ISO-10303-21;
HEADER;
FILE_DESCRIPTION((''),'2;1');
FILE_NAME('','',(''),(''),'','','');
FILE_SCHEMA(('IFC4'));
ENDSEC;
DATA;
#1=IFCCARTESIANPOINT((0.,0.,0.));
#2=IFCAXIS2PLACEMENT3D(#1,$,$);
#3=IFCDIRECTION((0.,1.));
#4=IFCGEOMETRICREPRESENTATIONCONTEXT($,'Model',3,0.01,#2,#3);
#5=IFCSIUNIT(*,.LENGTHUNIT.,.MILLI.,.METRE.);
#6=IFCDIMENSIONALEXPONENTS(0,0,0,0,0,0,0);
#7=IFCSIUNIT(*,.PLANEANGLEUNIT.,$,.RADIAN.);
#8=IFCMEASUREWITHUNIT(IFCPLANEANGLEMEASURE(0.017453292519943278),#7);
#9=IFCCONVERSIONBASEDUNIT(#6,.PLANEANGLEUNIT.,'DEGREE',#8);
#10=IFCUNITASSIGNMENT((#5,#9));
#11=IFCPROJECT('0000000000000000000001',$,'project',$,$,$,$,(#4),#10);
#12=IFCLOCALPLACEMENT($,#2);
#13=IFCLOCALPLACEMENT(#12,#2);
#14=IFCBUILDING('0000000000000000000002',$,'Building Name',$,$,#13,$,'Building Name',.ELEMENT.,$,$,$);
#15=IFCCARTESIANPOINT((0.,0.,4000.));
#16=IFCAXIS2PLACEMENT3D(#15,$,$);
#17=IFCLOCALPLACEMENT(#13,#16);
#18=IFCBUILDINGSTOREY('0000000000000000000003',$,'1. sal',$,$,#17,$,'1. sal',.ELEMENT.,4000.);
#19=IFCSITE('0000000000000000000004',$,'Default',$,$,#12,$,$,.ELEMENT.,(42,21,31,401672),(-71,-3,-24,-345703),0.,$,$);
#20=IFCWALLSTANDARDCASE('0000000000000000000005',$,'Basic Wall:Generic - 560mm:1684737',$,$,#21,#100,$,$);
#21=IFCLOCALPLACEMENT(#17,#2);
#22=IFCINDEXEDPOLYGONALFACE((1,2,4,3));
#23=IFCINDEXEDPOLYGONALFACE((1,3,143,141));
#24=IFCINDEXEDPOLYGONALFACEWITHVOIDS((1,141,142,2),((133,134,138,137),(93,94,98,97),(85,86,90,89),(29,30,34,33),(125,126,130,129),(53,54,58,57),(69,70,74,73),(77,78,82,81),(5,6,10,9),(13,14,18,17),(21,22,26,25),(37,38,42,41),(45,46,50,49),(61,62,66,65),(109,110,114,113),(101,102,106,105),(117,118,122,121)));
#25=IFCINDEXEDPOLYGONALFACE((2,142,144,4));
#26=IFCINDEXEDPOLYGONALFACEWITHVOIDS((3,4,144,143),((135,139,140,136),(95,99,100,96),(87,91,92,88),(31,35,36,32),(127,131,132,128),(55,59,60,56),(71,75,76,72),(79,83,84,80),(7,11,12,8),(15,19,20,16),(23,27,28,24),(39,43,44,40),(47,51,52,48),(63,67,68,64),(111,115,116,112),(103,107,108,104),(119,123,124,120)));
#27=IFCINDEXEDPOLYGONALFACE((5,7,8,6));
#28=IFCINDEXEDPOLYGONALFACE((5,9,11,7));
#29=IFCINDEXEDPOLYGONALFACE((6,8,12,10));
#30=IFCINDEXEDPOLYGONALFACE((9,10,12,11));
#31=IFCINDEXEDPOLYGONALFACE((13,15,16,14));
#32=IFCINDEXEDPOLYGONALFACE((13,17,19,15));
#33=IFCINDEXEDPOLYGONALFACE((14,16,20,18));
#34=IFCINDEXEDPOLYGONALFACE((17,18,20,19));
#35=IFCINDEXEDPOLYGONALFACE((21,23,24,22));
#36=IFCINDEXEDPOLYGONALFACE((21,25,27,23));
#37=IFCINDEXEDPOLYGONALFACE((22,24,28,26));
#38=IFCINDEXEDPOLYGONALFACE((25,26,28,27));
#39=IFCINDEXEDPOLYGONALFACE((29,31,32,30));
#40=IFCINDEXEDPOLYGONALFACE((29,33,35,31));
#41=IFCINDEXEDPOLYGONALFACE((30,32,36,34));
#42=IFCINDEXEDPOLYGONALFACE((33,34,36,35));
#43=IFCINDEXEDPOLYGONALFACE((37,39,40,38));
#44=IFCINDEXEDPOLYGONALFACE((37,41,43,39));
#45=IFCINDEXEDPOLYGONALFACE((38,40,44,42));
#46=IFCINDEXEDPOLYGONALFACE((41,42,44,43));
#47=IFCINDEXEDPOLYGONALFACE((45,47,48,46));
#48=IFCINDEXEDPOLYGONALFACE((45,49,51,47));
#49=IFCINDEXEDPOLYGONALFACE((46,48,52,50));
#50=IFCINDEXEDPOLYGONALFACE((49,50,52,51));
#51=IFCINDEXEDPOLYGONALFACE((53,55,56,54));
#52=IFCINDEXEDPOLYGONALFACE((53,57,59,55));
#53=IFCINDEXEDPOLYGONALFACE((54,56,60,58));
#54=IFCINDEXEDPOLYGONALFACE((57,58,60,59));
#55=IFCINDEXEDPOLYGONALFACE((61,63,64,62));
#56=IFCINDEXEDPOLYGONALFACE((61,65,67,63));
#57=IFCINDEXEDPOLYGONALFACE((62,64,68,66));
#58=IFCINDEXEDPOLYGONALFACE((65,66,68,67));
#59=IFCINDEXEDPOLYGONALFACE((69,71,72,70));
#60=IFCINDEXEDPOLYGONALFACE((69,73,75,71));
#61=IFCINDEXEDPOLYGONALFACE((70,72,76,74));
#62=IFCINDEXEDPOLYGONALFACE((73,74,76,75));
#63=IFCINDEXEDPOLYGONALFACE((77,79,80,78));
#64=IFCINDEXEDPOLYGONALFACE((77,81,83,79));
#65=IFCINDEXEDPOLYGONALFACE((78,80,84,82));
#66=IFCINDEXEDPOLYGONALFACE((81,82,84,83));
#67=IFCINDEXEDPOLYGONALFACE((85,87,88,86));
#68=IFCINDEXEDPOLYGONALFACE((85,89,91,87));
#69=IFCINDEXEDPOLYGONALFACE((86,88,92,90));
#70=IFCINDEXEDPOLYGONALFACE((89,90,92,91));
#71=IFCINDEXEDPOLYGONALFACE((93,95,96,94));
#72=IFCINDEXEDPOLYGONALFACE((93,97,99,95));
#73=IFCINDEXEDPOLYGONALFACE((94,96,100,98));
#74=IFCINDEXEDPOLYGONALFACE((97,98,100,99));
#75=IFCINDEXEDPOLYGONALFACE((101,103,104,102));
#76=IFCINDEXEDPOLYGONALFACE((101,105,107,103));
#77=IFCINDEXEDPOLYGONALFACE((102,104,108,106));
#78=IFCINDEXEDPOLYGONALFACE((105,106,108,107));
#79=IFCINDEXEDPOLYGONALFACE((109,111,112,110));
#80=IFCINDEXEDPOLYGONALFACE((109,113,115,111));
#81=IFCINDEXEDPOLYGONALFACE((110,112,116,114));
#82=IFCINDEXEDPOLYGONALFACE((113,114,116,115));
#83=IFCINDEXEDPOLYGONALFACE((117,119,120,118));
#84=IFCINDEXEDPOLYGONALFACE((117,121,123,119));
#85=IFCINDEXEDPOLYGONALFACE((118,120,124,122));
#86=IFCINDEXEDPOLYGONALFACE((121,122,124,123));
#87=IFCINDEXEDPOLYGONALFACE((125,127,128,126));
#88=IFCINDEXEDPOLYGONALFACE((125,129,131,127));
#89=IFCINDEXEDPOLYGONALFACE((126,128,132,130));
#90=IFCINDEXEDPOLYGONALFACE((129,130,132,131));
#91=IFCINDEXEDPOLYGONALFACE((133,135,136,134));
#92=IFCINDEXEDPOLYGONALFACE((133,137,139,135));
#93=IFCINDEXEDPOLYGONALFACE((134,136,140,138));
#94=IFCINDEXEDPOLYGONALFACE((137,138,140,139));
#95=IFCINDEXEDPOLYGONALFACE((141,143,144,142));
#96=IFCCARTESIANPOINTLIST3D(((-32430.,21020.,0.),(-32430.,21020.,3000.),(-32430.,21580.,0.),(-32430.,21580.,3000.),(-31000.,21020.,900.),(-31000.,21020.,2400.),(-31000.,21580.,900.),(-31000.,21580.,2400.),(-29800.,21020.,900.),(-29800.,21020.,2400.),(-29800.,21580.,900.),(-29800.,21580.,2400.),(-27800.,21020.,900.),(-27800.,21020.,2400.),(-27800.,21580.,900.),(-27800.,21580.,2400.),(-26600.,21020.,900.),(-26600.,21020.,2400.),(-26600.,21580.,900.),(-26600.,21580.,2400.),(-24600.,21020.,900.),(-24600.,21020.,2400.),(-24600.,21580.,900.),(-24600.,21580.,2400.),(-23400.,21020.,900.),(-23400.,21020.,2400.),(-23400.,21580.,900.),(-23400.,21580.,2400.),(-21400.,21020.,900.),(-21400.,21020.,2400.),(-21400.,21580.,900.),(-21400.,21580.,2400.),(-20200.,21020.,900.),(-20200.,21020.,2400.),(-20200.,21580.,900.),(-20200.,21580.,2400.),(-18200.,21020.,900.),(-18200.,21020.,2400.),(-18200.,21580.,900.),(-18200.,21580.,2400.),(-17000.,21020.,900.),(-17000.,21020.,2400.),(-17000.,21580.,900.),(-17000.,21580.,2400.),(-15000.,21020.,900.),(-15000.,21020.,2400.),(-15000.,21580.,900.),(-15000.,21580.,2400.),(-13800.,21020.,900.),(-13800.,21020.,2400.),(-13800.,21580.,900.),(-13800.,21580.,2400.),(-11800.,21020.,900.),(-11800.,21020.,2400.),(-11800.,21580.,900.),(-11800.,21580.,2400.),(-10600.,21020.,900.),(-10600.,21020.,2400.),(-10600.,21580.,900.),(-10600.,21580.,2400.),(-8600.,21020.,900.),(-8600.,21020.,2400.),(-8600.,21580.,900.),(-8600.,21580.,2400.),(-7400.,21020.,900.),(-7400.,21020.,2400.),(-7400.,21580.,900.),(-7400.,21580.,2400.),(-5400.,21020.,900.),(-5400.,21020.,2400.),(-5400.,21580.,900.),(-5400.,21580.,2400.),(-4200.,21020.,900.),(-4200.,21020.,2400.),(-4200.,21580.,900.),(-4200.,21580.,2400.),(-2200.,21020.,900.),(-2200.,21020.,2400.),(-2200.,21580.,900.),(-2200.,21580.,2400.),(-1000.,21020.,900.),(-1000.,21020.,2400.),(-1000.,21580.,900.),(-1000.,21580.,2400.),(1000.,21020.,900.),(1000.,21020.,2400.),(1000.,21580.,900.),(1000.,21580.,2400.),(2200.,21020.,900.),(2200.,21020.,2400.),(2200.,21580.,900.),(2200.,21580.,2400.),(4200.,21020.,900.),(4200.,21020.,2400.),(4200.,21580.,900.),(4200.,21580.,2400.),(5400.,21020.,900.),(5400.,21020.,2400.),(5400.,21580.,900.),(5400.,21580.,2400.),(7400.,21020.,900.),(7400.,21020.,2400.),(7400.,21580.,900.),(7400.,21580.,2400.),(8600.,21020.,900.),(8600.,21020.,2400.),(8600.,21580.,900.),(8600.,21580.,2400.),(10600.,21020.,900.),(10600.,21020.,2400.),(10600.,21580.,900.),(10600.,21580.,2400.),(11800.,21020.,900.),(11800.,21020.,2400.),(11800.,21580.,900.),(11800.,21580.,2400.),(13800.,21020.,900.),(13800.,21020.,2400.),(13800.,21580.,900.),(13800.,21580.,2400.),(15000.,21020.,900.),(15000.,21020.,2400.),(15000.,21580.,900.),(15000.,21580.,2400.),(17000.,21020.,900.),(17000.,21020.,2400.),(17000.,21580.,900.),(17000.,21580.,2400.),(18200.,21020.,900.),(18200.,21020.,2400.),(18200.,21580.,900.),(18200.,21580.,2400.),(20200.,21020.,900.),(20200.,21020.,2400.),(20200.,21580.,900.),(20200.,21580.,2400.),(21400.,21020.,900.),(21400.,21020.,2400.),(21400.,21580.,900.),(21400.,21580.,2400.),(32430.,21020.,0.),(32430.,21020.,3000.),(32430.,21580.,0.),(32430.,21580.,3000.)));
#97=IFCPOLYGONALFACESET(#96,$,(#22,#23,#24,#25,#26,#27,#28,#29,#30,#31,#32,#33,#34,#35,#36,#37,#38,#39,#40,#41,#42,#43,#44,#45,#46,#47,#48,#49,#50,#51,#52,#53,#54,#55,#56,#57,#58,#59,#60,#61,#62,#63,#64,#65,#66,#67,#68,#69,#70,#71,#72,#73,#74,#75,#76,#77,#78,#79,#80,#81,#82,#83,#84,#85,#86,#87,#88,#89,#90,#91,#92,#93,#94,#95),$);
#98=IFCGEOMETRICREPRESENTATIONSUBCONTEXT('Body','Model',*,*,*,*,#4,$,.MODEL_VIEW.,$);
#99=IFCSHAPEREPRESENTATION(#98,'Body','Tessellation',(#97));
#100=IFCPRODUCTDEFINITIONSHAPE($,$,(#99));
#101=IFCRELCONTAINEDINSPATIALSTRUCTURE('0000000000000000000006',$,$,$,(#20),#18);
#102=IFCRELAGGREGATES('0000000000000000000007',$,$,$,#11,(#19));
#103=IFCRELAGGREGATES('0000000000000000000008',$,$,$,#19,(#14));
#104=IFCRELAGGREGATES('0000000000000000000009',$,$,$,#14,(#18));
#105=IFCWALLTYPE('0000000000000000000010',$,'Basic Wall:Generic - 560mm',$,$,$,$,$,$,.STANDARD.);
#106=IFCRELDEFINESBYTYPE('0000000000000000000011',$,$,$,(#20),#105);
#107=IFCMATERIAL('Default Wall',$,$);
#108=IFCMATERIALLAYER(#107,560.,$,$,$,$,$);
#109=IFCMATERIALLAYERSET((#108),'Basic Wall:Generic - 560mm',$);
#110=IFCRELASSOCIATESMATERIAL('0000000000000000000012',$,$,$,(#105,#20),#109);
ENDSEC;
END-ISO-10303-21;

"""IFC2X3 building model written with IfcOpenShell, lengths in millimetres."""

from ifc_helpers import new_model, entity, si_unit, converted_unit, direction, frame, frame_2d, origin, place, context, subcontext, project, spatial, rectangle, extrude, material, layer, layer_set, layer_usage, type_object, element, save


model = new_model("IFC2X3")

# Units and contexts
model_context = context("Model", 3, precision=0.01, world=origin(), true_north=direction((0.0, 1.0)))
body_context = subcontext(model_context, "Body", "Model", "MODEL_VIEW")
ifc_project = project(units=[si_unit("LENGTHUNIT", "METRE", prefix="MILLI"), converted_unit("PLANEANGLEUNIT", "DEGREE", entity("IfcPlaneAngleMeasure", 0.017453292519943278), si_unit("PLANEANGLEUNIT", "RADIAN"), dimensions=[0, 0, 0, 0, 0, 0, 0])], contexts=[model_context])

# Site, building, storey
site_placement = place(None, origin())
site = spatial("IfcSite", under=ifc_project, at=site_placement, Name="Default", CompositionType="ELEMENT", RefLatitude=(42, 21, 31, 401672), RefLongitude=(-71, -3, -24, -345703), RefElevation=0.0)
building_placement = place(site_placement, origin())
building = spatial("IfcBuilding", under=site, at=building_placement, Name="Building Name", LongName="Building Name", CompositionType="ELEMENT")
storey_placement = place(building_placement, frame((0.0, 0.0, 4000.0)))
storey = spatial("IfcBuildingStorey", under=building, at=storey_placement, Name="1. sal", LongName="1. sal", CompositionType="ELEMENT", Elevation=4000.0)

# Wall, openings
ifc_material_1 = material(Name="Default Wall")
ifc_layer = layer(ifc_material_1, 560.0)
ifc_layer_set = layer_set([ifc_layer], Name="Basic Wall:Generic - 560mm")
ifc_layer_usage = layer_usage(ifc_layer_set, "AXIS2", "NEGATIVE", 280.0)
wall_type = type_object("IfcWallType", Name="Basic Wall:Generic - 560mm", PredefinedType="STANDARD", material=ifc_layer_set)
wall_placement = place(storey_placement, frame((-32430.0, 21300.0, 0.0)))
wall = element("IfcWallStandardCase", 1, at=wall_placement, inside=storey, type_object=wall_type, material=ifc_layer_usage, Name="Basic Wall:Generic - 560mm:1684737", context=body_context, shape_type="SweptSolid", body=[
    extrude(rectangle(XDim=64860.0, YDim=560.0, at=frame_2d((32430.0, 0.0), x_axis=(-1.0, 0.0))), origin(), (0.0, 0.0, 1.0), 3000.0),
])
opening_1_placement = place(wall_placement, frame((52630.0, -280.0, 900.0)))
element("IfcOpeningElement", 2, at=opening_1_placement, cuts=wall, ObjectType="Opening", context=body_context, shape_type="SweptSolid", body=[
    extrude(rectangle(XDim=1500.0, YDim=1200.0, at=frame_2d((750.0, 600.0), x_axis=(-1.0, 0.0))), frame((0.0, 0.0, 0.0), z_axis=(0.0, 1.0, 0.0), x_axis=(0.0, 0.0, 1.0)), (0.0, 0.0, 1.0), 560.0),
])
opening_2_placement = place(wall_placement, frame((49430.0, -280.0, 900.0)))
element("IfcOpeningElement", 3, at=opening_2_placement, cuts=wall, ObjectType="Opening", context=body_context, shape_type="SweptSolid", body=[
    extrude(rectangle(XDim=1500.0, YDim=1200.0, at=frame_2d((750.0, 600.0), x_axis=(-1.0, 0.0))), frame((0.0, 0.0, 0.0), z_axis=(0.0, 1.0, 0.0), x_axis=(0.0, 0.0, 1.0)), (0.0, 0.0, 1.0), 560.0),
])
opening_3_placement = place(wall_placement, frame((46230.0, -280.0, 900.0)))
element("IfcOpeningElement", 4, at=opening_3_placement, cuts=wall, ObjectType="Opening", context=body_context, shape_type="SweptSolid", body=[
    extrude(rectangle(XDim=1500.0, YDim=1200.0, at=frame_2d((750.0, 600.0), x_axis=(-1.0, 0.0))), frame((0.0, 0.0, 0.0), z_axis=(0.0, 1.0, 0.0), x_axis=(0.0, 0.0, 1.0)), (0.0, 0.0, 1.0), 560.0),
])
opening_4_placement = place(wall_placement, frame((43030.0, -280.0, 900.0)))
element("IfcOpeningElement", 5, at=opening_4_placement, cuts=wall, ObjectType="Opening", context=body_context, shape_type="SweptSolid", body=[
    extrude(rectangle(XDim=1500.0, YDim=1200.0, at=frame_2d((750.0, 600.0), x_axis=(-1.0, 0.0))), frame((0.0, 0.0, 0.0), z_axis=(0.0, 1.0, 0.0), x_axis=(0.0, 0.0, 1.0)), (0.0, 0.0, 1.0), 560.0),
])
opening_5_placement = place(wall_placement, frame((39830.0, -280.0, 900.0)))
element("IfcOpeningElement", 6, at=opening_5_placement, cuts=wall, ObjectType="Opening", context=body_context, shape_type="SweptSolid", body=[
    extrude(rectangle(XDim=1500.0, YDim=1200.0, at=frame_2d((750.0, 600.0), x_axis=(-1.0, 0.0))), frame((0.0, 0.0, 0.0), z_axis=(0.0, 1.0, 0.0), x_axis=(0.0, 0.0, 1.0)), (0.0, 0.0, 1.0), 560.0),
])
opening_6_placement = place(wall_placement, frame((36630.0, -280.0, 900.0)))
element("IfcOpeningElement", 7, at=opening_6_placement, cuts=wall, ObjectType="Opening", context=body_context, shape_type="SweptSolid", body=[
    extrude(rectangle(XDim=1500.0, YDim=1200.0, at=frame_2d((750.0, 600.0), x_axis=(-1.0, 0.0))), frame((0.0, 0.0, 0.0), z_axis=(0.0, 1.0, 0.0), x_axis=(0.0, 0.0, 1.0)), (0.0, 0.0, 1.0), 560.0),
])
opening_7_placement = place(wall_placement, frame((33430.0, -280.0, 900.0)))
element("IfcOpeningElement", 8, at=opening_7_placement, cuts=wall, ObjectType="Opening", context=body_context, shape_type="SweptSolid", body=[
    extrude(rectangle(XDim=1500.0, YDim=1200.0, at=frame_2d((750.0, 600.0), x_axis=(-1.0, 0.0))), frame((0.0, 0.0, 0.0), z_axis=(0.0, 1.0, 0.0), x_axis=(0.0, 0.0, 1.0)), (0.0, 0.0, 1.0), 560.0),
])
opening_8_placement = place(wall_placement, frame((30230.0, -280.0, 900.0)))
element("IfcOpeningElement", 9, at=opening_8_placement, cuts=wall, ObjectType="Opening", context=body_context, shape_type="SweptSolid", body=[
    extrude(rectangle(XDim=1500.0, YDim=1200.0, at=frame_2d((750.0, 600.0), x_axis=(-1.0, 0.0))), frame((0.0, 0.0, 0.0), z_axis=(0.0, 1.0, 0.0), x_axis=(0.0, 0.0, 1.0)), (0.0, 0.0, 1.0), 560.0),
])
opening_9_placement = place(wall_placement, frame((27030.0, -280.0, 900.0)))
element("IfcOpeningElement", 10, at=opening_9_placement, cuts=wall, ObjectType="Opening", context=body_context, shape_type="SweptSolid", body=[
    extrude(rectangle(XDim=1500.0, YDim=1200.0, at=frame_2d((750.0, 600.0), x_axis=(-1.0, 0.0))), frame((0.0, 0.0, 0.0), z_axis=(0.0, 1.0, 0.0), x_axis=(0.0, 0.0, 1.0)), (0.0, 0.0, 1.0), 560.0),
])
opening_10_placement = place(wall_placement, frame((23830.0, -280.0, 900.0)))
element("IfcOpeningElement", 11, at=opening_10_placement, cuts=wall, ObjectType="Opening", context=body_context, shape_type="SweptSolid", body=[
    extrude(rectangle(XDim=1500.0, YDim=1200.0, at=frame_2d((750.0, 600.0), x_axis=(-1.0, 0.0))), frame((0.0, 0.0, 0.0), z_axis=(0.0, 1.0, 0.0), x_axis=(0.0, 0.0, 1.0)), (0.0, 0.0, 1.0), 560.0),
])
opening_11_placement = place(wall_placement, frame((20630.0, -280.0, 900.0)))
element("IfcOpeningElement", 12, at=opening_11_placement, cuts=wall, ObjectType="Opening", context=body_context, shape_type="SweptSolid", body=[
    extrude(rectangle(XDim=1500.0, YDim=1200.0, at=frame_2d((750.0, 600.0), x_axis=(-1.0, 0.0))), frame((0.0, 0.0, 0.0), z_axis=(0.0, 1.0, 0.0), x_axis=(0.0, 0.0, 1.0)), (0.0, 0.0, 1.0), 560.0),
])
opening_12_placement = place(wall_placement, frame((17430.0, -280.0, 900.0)))
element("IfcOpeningElement", 13, at=opening_12_placement, cuts=wall, ObjectType="Opening", context=body_context, shape_type="SweptSolid", body=[
    extrude(rectangle(XDim=1500.0, YDim=1200.0, at=frame_2d((750.0, 600.0), x_axis=(-1.0, 0.0))), frame((0.0, 0.0, 0.0), z_axis=(0.0, 1.0, 0.0), x_axis=(0.0, 0.0, 1.0)), (0.0, 0.0, 1.0), 560.0),
])
opening_13_placement = place(wall_placement, frame((14230.0, -280.0, 900.0)))
element("IfcOpeningElement", 14, at=opening_13_placement, cuts=wall, ObjectType="Opening", context=body_context, shape_type="SweptSolid", body=[
    extrude(rectangle(XDim=1500.0, YDim=1200.0, at=frame_2d((750.0, 600.0), x_axis=(-1.0, 0.0))), frame((0.0, 0.0, 0.0), z_axis=(0.0, 1.0, 0.0), x_axis=(0.0, 0.0, 1.0)), (0.0, 0.0, 1.0), 560.0),
])
opening_14_placement = place(wall_placement, frame((11030.0, -280.0, 900.0)))
element("IfcOpeningElement", 15, at=opening_14_placement, cuts=wall, ObjectType="Opening", context=body_context, shape_type="SweptSolid", body=[
    extrude(rectangle(XDim=1500.0, YDim=1200.0, at=frame_2d((750.0, 600.0), x_axis=(-1.0, 0.0))), frame((0.0, 0.0, 0.0), z_axis=(0.0, 1.0, 0.0), x_axis=(0.0, 0.0, 1.0)), (0.0, 0.0, 1.0), 560.0),
])
opening_15_placement = place(wall_placement, frame((7830.0, -280.0, 900.0)))
element("IfcOpeningElement", 16, at=opening_15_placement, cuts=wall, ObjectType="Opening", context=body_context, shape_type="SweptSolid", body=[
    extrude(rectangle(XDim=1500.0, YDim=1200.0, at=frame_2d((750.0, 600.0), x_axis=(-1.0, 0.0))), frame((0.0, 0.0, 0.0), z_axis=(0.0, 1.0, 0.0), x_axis=(0.0, 0.0, 1.0)), (0.0, 0.0, 1.0), 560.0),
])
opening_16_placement = place(wall_placement, frame((4630.0, -280.0, 900.0)))
element("IfcOpeningElement", 17, at=opening_16_placement, cuts=wall, ObjectType="Opening", context=body_context, shape_type="SweptSolid", body=[
    extrude(rectangle(XDim=1500.0, YDim=1200.0, at=frame_2d((750.0, 600.0), x_axis=(-1.0, 0.0))), frame((0.0, 0.0, 0.0), z_axis=(0.0, 1.0, 0.0), x_axis=(0.0, 0.0, 1.0)), (0.0, 0.0, 1.0), 560.0),
])
opening_17_placement = place(wall_placement, frame((1430.0, -280.0, 900.0)))
element("IfcOpeningElement", 18, at=opening_17_placement, cuts=wall, ObjectType="Opening", context=body_context, shape_type="SweptSolid", body=[
    extrude(rectangle(XDim=1500.0, YDim=1200.0, at=frame_2d((750.0, 600.0), x_axis=(-1.0, 0.0))), frame((0.0, 0.0, 0.0), z_axis=(0.0, 1.0, 0.0), x_axis=(0.0, 0.0, 1.0)), (0.0, 0.0, 1.0), 560.0),
])

save(model, "model.ifc")
